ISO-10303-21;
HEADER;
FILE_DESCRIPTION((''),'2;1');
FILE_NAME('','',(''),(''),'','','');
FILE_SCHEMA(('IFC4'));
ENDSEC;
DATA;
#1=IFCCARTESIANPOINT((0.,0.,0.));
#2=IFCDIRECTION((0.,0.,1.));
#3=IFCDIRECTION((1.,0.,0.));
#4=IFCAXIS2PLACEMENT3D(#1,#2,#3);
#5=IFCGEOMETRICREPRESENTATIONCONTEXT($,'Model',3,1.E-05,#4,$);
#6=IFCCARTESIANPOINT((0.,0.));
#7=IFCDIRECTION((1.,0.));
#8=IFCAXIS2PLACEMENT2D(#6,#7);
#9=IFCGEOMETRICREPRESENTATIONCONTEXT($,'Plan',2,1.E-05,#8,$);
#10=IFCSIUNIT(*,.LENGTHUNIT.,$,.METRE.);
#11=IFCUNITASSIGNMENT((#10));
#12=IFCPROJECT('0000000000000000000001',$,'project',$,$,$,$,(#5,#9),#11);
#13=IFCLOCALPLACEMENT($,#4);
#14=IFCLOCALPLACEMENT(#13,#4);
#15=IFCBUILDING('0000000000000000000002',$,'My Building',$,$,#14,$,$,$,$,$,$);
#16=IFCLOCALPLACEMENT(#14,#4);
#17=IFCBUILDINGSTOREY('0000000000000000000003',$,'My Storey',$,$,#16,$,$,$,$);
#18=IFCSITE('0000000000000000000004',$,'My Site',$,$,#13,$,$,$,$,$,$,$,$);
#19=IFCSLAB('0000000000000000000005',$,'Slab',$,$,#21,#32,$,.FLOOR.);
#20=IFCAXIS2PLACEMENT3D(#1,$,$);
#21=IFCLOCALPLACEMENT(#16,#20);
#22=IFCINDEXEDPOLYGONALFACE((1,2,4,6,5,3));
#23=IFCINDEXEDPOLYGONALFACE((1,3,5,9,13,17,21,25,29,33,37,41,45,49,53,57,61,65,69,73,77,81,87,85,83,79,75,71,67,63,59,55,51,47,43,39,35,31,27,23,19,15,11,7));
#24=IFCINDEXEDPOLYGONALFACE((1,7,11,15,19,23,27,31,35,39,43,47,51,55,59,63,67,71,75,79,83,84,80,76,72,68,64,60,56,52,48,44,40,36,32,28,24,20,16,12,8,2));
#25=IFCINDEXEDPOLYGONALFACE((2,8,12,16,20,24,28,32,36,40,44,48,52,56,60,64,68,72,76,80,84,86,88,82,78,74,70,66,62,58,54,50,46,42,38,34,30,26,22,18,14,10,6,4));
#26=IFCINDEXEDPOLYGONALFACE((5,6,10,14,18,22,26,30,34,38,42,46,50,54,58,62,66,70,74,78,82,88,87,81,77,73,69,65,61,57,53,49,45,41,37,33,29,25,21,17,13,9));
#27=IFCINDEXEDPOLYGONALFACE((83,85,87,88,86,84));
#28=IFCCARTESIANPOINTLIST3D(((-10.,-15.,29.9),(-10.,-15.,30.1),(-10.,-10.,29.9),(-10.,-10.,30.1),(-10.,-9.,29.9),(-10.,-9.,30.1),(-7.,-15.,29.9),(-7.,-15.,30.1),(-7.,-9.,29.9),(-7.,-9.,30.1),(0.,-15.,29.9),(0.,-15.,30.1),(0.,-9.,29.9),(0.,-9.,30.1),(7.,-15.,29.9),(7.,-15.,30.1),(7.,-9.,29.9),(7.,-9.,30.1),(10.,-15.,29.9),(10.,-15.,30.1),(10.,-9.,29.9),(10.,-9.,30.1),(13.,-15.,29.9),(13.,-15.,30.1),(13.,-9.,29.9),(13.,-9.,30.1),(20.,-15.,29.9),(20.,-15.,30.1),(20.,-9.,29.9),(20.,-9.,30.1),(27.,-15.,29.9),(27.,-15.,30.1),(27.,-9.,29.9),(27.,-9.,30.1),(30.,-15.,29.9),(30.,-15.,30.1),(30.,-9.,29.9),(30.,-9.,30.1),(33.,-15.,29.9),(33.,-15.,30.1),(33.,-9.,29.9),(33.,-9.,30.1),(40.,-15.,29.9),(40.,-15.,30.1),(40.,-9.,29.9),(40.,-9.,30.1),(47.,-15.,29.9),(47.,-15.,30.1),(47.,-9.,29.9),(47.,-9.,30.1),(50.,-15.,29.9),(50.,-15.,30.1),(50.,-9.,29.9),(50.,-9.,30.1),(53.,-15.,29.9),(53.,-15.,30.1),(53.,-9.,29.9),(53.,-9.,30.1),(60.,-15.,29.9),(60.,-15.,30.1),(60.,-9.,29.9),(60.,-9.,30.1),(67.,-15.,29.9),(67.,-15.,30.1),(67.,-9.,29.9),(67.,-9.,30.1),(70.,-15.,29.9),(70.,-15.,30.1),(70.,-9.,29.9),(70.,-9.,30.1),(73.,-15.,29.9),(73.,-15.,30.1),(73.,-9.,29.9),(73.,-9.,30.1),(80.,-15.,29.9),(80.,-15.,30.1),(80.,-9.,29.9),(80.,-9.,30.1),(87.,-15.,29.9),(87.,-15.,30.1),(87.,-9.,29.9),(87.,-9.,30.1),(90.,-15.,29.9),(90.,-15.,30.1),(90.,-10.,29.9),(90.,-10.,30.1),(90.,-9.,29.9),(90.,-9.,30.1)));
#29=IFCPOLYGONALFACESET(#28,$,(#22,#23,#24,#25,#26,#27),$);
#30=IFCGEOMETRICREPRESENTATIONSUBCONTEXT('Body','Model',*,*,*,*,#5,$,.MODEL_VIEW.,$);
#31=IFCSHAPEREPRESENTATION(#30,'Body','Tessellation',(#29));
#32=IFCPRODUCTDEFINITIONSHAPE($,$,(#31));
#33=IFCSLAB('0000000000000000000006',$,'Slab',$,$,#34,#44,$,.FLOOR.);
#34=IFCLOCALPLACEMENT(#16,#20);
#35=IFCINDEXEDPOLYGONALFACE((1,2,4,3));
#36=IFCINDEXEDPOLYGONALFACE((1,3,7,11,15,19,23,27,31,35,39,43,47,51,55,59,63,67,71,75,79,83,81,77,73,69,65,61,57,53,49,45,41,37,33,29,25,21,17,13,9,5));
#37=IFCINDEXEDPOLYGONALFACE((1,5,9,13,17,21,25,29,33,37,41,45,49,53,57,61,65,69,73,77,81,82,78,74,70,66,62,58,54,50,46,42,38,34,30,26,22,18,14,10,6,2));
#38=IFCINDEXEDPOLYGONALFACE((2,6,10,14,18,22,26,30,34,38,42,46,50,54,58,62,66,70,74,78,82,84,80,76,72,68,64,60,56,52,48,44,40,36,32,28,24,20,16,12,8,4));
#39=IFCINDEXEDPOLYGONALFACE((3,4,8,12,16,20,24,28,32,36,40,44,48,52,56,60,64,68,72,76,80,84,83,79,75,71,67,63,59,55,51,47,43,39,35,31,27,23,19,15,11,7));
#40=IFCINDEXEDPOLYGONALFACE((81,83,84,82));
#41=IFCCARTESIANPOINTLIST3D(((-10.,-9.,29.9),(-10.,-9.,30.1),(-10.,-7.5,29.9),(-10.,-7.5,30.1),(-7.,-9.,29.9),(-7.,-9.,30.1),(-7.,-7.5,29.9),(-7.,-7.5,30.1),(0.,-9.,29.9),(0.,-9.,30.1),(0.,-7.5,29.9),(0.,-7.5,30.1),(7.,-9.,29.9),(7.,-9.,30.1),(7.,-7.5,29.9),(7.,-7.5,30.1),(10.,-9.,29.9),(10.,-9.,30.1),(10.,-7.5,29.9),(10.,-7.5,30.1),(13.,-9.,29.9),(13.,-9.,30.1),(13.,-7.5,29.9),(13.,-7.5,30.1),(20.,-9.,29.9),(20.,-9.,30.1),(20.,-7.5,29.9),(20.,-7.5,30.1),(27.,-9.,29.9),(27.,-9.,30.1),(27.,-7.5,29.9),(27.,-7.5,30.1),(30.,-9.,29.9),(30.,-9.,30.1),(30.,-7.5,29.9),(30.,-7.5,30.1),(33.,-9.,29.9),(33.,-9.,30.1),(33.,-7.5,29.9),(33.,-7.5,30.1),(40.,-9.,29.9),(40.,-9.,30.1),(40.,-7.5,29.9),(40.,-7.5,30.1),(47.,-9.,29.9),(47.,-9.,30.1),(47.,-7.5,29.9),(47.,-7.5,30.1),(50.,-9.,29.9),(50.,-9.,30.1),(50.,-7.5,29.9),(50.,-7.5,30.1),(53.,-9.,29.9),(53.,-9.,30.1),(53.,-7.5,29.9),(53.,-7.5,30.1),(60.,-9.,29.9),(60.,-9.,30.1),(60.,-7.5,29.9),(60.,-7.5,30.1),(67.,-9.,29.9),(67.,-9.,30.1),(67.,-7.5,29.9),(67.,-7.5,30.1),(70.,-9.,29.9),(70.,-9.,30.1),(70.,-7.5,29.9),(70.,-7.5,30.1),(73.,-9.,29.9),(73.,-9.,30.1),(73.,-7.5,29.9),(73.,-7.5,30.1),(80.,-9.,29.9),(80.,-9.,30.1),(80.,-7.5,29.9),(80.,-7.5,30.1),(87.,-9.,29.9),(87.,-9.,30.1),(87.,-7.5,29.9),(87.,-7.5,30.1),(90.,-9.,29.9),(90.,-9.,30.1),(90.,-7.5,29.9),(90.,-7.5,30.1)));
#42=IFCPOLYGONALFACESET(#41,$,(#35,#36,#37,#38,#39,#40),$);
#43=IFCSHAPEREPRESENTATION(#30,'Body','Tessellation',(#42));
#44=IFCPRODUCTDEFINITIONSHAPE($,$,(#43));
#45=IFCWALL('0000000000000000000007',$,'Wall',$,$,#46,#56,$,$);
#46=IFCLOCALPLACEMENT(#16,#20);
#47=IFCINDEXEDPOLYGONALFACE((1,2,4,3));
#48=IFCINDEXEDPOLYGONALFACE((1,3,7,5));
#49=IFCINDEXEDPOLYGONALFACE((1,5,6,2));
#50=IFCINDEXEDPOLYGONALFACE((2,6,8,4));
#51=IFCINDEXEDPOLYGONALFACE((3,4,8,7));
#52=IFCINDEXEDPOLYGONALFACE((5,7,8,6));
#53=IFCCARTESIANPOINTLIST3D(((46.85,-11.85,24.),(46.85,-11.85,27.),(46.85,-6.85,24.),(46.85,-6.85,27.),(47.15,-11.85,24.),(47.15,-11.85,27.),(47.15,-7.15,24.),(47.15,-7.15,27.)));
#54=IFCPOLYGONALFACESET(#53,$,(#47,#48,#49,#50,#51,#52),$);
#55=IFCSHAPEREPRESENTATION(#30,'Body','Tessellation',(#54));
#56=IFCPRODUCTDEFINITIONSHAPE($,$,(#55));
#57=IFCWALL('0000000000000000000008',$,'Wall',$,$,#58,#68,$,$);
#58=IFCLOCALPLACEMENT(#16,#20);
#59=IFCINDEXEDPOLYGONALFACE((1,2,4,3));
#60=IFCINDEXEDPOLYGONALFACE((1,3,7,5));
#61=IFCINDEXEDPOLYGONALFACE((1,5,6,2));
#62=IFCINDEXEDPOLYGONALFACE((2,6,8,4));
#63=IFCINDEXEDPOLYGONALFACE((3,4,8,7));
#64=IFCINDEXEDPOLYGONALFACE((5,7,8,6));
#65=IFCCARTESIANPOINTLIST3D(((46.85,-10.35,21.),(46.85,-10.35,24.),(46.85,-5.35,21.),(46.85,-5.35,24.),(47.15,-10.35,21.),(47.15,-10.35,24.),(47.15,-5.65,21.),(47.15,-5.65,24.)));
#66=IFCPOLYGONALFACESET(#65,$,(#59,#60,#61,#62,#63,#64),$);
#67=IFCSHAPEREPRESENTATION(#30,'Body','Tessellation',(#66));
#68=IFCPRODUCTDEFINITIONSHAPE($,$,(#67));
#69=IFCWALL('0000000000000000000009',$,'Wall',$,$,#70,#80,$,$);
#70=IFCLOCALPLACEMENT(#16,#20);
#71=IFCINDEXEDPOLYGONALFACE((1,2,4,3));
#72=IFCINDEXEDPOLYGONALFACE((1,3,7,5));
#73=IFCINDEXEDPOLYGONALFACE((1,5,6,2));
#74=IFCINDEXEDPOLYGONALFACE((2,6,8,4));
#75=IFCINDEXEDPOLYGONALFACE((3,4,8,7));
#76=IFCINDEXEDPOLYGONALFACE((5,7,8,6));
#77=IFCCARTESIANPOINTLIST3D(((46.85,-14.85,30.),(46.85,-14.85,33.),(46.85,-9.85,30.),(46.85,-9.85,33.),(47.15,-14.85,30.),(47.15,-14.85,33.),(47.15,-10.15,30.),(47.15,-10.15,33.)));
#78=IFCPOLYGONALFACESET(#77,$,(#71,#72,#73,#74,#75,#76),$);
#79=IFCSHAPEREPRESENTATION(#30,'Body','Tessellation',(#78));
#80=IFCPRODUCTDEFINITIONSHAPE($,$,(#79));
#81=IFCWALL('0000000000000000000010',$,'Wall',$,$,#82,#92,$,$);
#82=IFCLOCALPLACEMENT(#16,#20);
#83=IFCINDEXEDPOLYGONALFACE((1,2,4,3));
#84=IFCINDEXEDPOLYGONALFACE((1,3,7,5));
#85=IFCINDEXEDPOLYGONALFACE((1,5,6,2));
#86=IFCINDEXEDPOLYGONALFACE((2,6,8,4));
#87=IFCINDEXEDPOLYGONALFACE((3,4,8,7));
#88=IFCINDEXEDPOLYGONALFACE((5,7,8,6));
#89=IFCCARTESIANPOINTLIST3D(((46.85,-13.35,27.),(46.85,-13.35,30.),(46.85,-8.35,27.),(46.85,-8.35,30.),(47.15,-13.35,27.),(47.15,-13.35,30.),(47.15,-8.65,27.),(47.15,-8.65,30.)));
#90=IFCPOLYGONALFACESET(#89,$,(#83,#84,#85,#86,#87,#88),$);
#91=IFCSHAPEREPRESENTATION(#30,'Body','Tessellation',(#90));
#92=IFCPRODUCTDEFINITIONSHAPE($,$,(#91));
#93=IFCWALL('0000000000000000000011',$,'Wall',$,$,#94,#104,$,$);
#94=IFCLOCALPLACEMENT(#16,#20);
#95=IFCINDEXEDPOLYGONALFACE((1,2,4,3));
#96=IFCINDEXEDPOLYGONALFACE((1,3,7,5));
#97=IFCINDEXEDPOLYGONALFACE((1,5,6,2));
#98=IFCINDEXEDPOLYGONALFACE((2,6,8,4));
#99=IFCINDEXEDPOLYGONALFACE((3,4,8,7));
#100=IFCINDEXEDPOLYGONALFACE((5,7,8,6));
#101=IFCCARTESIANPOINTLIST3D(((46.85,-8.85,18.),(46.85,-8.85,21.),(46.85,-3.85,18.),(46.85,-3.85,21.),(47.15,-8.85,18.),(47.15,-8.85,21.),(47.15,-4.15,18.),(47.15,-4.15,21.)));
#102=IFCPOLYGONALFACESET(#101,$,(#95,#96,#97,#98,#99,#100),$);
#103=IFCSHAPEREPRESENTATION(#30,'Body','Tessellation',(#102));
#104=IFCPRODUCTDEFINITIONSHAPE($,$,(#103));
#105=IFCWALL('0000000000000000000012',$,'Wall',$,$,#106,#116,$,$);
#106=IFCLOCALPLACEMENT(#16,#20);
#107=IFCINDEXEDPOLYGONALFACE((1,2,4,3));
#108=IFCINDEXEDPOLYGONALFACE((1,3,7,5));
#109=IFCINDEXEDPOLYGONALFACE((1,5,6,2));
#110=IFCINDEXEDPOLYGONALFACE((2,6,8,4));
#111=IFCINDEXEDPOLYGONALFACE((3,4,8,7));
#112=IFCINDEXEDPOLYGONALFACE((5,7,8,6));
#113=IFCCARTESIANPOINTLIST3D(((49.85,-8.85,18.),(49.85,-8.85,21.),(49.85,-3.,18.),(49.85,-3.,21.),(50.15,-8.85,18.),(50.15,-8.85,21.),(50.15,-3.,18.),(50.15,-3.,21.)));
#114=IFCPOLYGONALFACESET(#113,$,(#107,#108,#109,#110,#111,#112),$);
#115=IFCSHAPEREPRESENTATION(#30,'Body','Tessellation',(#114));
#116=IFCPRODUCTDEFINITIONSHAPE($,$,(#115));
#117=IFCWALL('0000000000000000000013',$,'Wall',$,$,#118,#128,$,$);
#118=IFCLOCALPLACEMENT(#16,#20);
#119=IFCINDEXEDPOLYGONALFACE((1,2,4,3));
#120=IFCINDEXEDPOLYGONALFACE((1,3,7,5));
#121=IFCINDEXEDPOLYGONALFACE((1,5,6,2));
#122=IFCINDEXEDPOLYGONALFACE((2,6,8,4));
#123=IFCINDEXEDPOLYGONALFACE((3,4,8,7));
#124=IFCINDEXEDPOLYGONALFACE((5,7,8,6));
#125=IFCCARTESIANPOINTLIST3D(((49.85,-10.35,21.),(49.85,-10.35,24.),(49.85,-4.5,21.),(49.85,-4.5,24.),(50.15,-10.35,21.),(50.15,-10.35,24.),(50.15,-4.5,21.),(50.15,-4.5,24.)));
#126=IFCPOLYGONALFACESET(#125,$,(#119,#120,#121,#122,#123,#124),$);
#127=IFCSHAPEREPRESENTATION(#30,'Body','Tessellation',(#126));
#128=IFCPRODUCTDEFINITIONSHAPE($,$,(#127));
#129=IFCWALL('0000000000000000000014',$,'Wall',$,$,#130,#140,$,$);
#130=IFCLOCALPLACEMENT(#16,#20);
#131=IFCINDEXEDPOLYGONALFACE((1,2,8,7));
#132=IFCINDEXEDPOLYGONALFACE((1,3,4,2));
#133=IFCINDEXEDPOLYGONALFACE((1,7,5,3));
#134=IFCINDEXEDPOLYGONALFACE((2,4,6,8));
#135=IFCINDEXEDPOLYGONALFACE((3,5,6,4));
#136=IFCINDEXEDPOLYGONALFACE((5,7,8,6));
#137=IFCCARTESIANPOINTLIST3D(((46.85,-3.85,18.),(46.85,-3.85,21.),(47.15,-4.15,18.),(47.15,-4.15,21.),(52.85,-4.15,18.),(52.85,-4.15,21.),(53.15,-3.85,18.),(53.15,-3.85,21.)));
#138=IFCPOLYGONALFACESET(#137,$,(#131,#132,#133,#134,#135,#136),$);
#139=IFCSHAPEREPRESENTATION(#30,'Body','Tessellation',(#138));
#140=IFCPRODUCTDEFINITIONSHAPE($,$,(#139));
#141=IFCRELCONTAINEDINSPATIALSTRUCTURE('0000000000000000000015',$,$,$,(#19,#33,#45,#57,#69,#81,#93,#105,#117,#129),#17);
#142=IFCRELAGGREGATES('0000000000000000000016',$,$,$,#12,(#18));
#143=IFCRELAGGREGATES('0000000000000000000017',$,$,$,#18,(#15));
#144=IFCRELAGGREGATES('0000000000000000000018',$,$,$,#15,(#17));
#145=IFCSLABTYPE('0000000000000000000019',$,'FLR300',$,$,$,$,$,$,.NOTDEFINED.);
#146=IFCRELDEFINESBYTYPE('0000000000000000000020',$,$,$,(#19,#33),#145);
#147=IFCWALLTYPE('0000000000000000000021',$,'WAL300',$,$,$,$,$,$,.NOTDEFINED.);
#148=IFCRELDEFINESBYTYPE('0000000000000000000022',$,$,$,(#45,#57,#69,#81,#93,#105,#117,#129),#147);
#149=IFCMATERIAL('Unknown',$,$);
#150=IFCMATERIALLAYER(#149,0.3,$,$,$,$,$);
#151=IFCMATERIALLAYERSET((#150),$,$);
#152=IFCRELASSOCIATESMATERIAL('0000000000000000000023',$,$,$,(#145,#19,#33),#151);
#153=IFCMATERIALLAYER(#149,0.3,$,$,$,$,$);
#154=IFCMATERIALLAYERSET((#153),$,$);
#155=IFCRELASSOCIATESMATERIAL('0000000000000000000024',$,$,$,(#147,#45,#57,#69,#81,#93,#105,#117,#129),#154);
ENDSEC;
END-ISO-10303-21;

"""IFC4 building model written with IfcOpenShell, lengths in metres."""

from ifc_helpers import new_model, si_unit, frame, origin, origin_with_axes, origin_2d_with_axis, place, context, subcontext, project, spatial, polyline, line, indexed_curve, outline, extrude, material, layer, layer_set, layer_usage, type_object, element, save


model = new_model("IFC4")

# Units and contexts
model_context = context("Model", 3, precision=1e-05, world=origin_with_axes())
plan_context = context("Plan", 2, precision=1e-05, world=origin_2d_with_axis())
body_context = subcontext(model_context, "Body", "Model", "MODEL_VIEW")
ifc_project = project(units=[si_unit("LENGTHUNIT", "METRE")], contexts=[model_context, plan_context])

# Site, building, storey
site_placement = place(None, origin_with_axes())
site = spatial("IfcSite", under=ifc_project, at=site_placement, Name="My Site")
building_placement = place(site_placement, origin_with_axes())
building = spatial("IfcBuilding", under=site, at=building_placement, Name="My Building")
storey_placement = place(building_placement, origin_with_axes())
storey = spatial("IfcBuildingStorey", under=building, at=storey_placement, Name="My Storey")

# Slabs
ifc_material = material(Name="Unknown")
ifc_layer_1 = layer(ifc_material, 0.3)
ifc_layer_set_1 = layer_set([ifc_layer_1])
slab_type = type_object("IfcSlabType", Name="FLR300", PredefinedType="NOTDEFINED", material=ifc_layer_set_1)
ifc_layer_usage_1 = layer_usage(ifc_layer_set_1, "AXIS3", "POSITIVE", 0.0)
slab_1_placement = place(storey_placement, frame((40.0, -11.9091, 29.9), z_axis=(0.0, 0.0, 1.0), x_axis=(1.0, 0.0, 0.0)))
element("IfcSlab", 1, at=slab_1_placement, inside=storey, type_object=slab_type, material=ifc_layer_usage_1, Name="Slab", PredefinedType="FLOOR", context=body_context, shape_type="SweptSolid", body=[
    extrude(outline(polyline([(-47.0, 2.9091), (-50.0, 2.9091), (-50.0, 1.9091), (-50.0, -3.0909), (-47.0, -3.0909), (-40.0, -3.0909), (-33.0, -3.0909), (-30.0, -3.0909), (-27.0, -3.0909), (-20.0, -3.0909), (-13.0, -3.0909), (-10.0, -3.0909), (-7.0, -3.0909), (0.0, -3.0909), (7.0, -3.0909), (10.0, -3.0909), (13.0, -3.0909), (20.0, -3.0909), (27.0, -3.0909), (30.0, -3.0909), (33.0, -3.0909), (40.0, -3.0909), (47.0, -3.0909), (50.0, -3.0909), (50.0, 1.9091), (50.0, 2.9091), (47.0, 2.9091), (40.0, 2.9091), (33.0, 2.9091), (30.0, 2.9091), (27.0, 2.9091), (20.0, 2.9091), (13.0, 2.9091), (10.0, 2.9091), (7.0, 2.9091), (0.0, 2.9091), (-7.0, 2.9091), (-10.0, 2.9091), (-13.0, 2.9091), (-20.0, 2.9091), (-27.0, 2.9091), (-30.0, 2.9091), (-33.0, 2.9091), (-40.0, 2.9091), (-47.0, 2.9091)])), origin(), (0.0, 0.0, 1.0), 0.2),
])
ifc_layer_usage_2 = layer_usage(ifc_layer_set_1, "AXIS3", "POSITIVE", 0.0)
slab_2_placement = place(storey_placement, frame((40.0, -8.25, 29.9), z_axis=(0.0, 0.0, 1.0), x_axis=(1.0, 0.0, 0.0)))
element("IfcSlab", 2, at=slab_2_placement, inside=storey, type_object=slab_type, material=ifc_layer_usage_2, Name="Slab", PredefinedType="FLOOR", context=body_context, shape_type="SweptSolid", body=[
    extrude(outline(polyline([(-40.0, -0.75), (-33.0, -0.75), (-30.0, -0.75), (-27.0, -0.75), (-20.0, -0.75), (-13.0, -0.75), (-10.0, -0.75), (-7.0, -0.75), (0.0, -0.75), (7.0, -0.75), (10.0, -0.75), (13.0, -0.75), (20.0, -0.75), (27.0, -0.75), (30.0, -0.75), (33.0, -0.75), (40.0, -0.75), (47.0, -0.75), (50.0, -0.75), (50.0, 0.75), (47.0, 0.75), (40.0, 0.75), (33.0, 0.75), (30.0, 0.75), (27.0, 0.75), (20.0, 0.75), (13.0, 0.75), (10.0, 0.75), (7.0, 0.75), (0.0, 0.75), (-7.0, 0.75), (-10.0, 0.75), (-13.0, 0.75), (-20.0, 0.75), (-27.0, 0.75), (-30.0, 0.75), (-33.0, 0.75), (-40.0, 0.75), (-47.0, 0.75), (-50.0, 0.75), (-50.0, -0.75), (-47.0, -0.75), (-40.0, -0.75)])), origin(), (0.0, 0.0, 1.0), 0.2),
])

# Walls
ifc_layer_2 = layer(ifc_material, 0.3)
ifc_layer_set_2 = layer_set([ifc_layer_2])
ifc_layer_usage_3 = layer_usage(ifc_layer_set_2, "AXIS2", "POSITIVE", -0.15)
wall_type = type_object("IfcWallType", Name="WAL300", PredefinedType="NOTDEFINED", material=ifc_layer_set_2)
wall_1_placement = place(storey_placement, frame((47.0, -7.0, 24.0), z_axis=(0.0, 0.0, 1.0), x_axis=(0.0, -1.0, 0.0)))
element("IfcWall", 3, at=wall_1_placement, inside=storey, type_object=wall_type, material=ifc_layer_usage_3, Name="Wall", context=body_context, shape_type="SweptSolid", body=[
    extrude(outline(indexed_curve([(-0.15, -0.15), (0.15, 0.15), (4.85, 0.15), (4.85, -0.15)], segments=[line(1, 2, 3, 4, 1)])), origin_with_axes(), (0.0, 0.0, 1.0), 3.0),
])
ifc_layer_usage_4 = layer_usage(ifc_layer_set_2, "AXIS2", "POSITIVE", -0.15)
wall_2_placement = place(storey_placement, frame((47.0, -5.5, 21.0), z_axis=(0.0, 0.0, 1.0), x_axis=(0.0, -1.0, 0.0)))
element("IfcWall", 4, at=wall_2_placement, inside=storey, type_object=wall_type, material=ifc_layer_usage_4, Name="Wall", context=body_context, shape_type="SweptSolid", body=[
    extrude(outline(indexed_curve([(-0.15, -0.15), (0.15, 0.15), (4.85, 0.15), (4.85, -0.15)], segments=[line(1, 2, 3, 4, 1)])), origin_with_axes(), (0.0, 0.0, 1.0), 3.0),
])
ifc_layer_usage_5 = layer_usage(ifc_layer_set_2, "AXIS2", "POSITIVE", -0.15)
wall_3_placement = place(storey_placement, frame((47.0, -10.0, 30.0), z_axis=(0.0, 0.0, 1.0), x_axis=(0.0, -1.0, 0.0)))
element("IfcWall", 5, at=wall_3_placement, inside=storey, type_object=wall_type, material=ifc_layer_usage_5, Name="Wall", context=body_context, shape_type="SweptSolid", body=[
    extrude(outline(indexed_curve([(-0.15, -0.15), (0.15, 0.15), (4.85, 0.15), (4.85, -0.15)], segments=[line(1, 2, 3, 4, 1)])), origin_with_axes(), (0.0, 0.0, 1.0), 3.0),
])
ifc_layer_usage_6 = layer_usage(ifc_layer_set_2, "AXIS2", "POSITIVE", -0.15)
wall_4_placement = place(storey_placement, frame((47.0, -8.5, 27.0), z_axis=(0.0, 0.0, 1.0), x_axis=(0.0, -1.0, 0.0)))
element("IfcWall", 6, at=wall_4_placement, inside=storey, type_object=wall_type, material=ifc_layer_usage_6, Name="Wall", context=body_context, shape_type="SweptSolid", body=[
    extrude(outline(indexed_curve([(-0.15, -0.15), (0.15, 0.15), (4.85, 0.15), (4.85, -0.15)], segments=[line(1, 2, 3, 4, 1)])), origin_with_axes(), (0.0, 0.0, 1.0), 3.0),
])
ifc_layer_usage_7 = layer_usage(ifc_layer_set_2, "AXIS2", "POSITIVE", -0.15)
wall_5_placement = place(storey_placement, frame((47.0, -4.0, 18.0), z_axis=(0.0, 0.0, 1.0), x_axis=(0.0, -1.0, 0.0)))
element("IfcWall", 7, at=wall_5_placement, inside=storey, type_object=wall_type, material=ifc_layer_usage_7, Name="Wall", context=body_context, shape_type="SweptSolid", body=[
    extrude(outline(indexed_curve([(-0.15, -0.15), (0.15, 0.15), (4.85, 0.15), (4.85, -0.15)], segments=[line(1, 2, 3, 4, 1)])), origin_with_axes(), (0.0, 0.0, 1.0), 3.0),
])
ifc_layer_usage_8 = layer_usage(ifc_layer_set_2, "AXIS2", "POSITIVE", -0.15)
wall_6_placement = place(storey_placement, frame((50.0, -3.0, 18.0), z_axis=(0.0, 0.0, 1.0), x_axis=(0.0, -1.0, 0.0)))
element("IfcWall", 8, at=wall_6_placement, inside=storey, type_object=wall_type, material=ifc_layer_usage_8, Name="Wall", context=body_context, shape_type="SweptSolid", body=[
    extrude(outline(indexed_curve([(0.0, -0.15), (0.0, 0.15), (5.85, 0.15), (5.85, -0.15)], segments=[line(1, 2, 3, 4, 1)])), origin_with_axes(), (0.0, 0.0, 1.0), 3.0),
])
ifc_layer_usage_9 = layer_usage(ifc_layer_set_2, "AXIS2", "POSITIVE", -0.15)
wall_7_placement = place(storey_placement, frame((50.0, -4.5, 21.0), z_axis=(0.0, 0.0, 1.0), x_axis=(0.0, -1.0, 0.0)))
element("IfcWall", 9, at=wall_7_placement, inside=storey, type_object=wall_type, material=ifc_layer_usage_9, Name="Wall", context=body_context, shape_type="SweptSolid", body=[
    extrude(outline(indexed_curve([(0.0, -0.15), (0.0, 0.15), (5.85, 0.15), (5.85, -0.15)], segments=[line(1, 2, 3, 4, 1)])), origin_with_axes(), (0.0, 0.0, 1.0), 3.0),
])
ifc_layer_usage_10 = layer_usage(ifc_layer_set_2, "AXIS2", "POSITIVE", -0.15)
wall_8_placement = place(storey_placement, frame((47.0, -4.0, 18.0), z_axis=(0.0, 0.0, 1.0), x_axis=(1.0, 0.0, 0.0)))
element("IfcWall", 10, at=wall_8_placement, inside=storey, type_object=wall_type, material=ifc_layer_usage_10, Name="Wall", context=body_context, shape_type="SweptSolid", body=[
    extrude(outline(indexed_curve([(0.15, -0.15), (-0.15, 0.15), (6.15, 0.15), (5.85, -0.15)], segments=[line(1, 2, 3, 4, 1)])), origin_with_axes(), (0.0, 0.0, 1.0), 3.0),
])

save(model, "model.ifc")
